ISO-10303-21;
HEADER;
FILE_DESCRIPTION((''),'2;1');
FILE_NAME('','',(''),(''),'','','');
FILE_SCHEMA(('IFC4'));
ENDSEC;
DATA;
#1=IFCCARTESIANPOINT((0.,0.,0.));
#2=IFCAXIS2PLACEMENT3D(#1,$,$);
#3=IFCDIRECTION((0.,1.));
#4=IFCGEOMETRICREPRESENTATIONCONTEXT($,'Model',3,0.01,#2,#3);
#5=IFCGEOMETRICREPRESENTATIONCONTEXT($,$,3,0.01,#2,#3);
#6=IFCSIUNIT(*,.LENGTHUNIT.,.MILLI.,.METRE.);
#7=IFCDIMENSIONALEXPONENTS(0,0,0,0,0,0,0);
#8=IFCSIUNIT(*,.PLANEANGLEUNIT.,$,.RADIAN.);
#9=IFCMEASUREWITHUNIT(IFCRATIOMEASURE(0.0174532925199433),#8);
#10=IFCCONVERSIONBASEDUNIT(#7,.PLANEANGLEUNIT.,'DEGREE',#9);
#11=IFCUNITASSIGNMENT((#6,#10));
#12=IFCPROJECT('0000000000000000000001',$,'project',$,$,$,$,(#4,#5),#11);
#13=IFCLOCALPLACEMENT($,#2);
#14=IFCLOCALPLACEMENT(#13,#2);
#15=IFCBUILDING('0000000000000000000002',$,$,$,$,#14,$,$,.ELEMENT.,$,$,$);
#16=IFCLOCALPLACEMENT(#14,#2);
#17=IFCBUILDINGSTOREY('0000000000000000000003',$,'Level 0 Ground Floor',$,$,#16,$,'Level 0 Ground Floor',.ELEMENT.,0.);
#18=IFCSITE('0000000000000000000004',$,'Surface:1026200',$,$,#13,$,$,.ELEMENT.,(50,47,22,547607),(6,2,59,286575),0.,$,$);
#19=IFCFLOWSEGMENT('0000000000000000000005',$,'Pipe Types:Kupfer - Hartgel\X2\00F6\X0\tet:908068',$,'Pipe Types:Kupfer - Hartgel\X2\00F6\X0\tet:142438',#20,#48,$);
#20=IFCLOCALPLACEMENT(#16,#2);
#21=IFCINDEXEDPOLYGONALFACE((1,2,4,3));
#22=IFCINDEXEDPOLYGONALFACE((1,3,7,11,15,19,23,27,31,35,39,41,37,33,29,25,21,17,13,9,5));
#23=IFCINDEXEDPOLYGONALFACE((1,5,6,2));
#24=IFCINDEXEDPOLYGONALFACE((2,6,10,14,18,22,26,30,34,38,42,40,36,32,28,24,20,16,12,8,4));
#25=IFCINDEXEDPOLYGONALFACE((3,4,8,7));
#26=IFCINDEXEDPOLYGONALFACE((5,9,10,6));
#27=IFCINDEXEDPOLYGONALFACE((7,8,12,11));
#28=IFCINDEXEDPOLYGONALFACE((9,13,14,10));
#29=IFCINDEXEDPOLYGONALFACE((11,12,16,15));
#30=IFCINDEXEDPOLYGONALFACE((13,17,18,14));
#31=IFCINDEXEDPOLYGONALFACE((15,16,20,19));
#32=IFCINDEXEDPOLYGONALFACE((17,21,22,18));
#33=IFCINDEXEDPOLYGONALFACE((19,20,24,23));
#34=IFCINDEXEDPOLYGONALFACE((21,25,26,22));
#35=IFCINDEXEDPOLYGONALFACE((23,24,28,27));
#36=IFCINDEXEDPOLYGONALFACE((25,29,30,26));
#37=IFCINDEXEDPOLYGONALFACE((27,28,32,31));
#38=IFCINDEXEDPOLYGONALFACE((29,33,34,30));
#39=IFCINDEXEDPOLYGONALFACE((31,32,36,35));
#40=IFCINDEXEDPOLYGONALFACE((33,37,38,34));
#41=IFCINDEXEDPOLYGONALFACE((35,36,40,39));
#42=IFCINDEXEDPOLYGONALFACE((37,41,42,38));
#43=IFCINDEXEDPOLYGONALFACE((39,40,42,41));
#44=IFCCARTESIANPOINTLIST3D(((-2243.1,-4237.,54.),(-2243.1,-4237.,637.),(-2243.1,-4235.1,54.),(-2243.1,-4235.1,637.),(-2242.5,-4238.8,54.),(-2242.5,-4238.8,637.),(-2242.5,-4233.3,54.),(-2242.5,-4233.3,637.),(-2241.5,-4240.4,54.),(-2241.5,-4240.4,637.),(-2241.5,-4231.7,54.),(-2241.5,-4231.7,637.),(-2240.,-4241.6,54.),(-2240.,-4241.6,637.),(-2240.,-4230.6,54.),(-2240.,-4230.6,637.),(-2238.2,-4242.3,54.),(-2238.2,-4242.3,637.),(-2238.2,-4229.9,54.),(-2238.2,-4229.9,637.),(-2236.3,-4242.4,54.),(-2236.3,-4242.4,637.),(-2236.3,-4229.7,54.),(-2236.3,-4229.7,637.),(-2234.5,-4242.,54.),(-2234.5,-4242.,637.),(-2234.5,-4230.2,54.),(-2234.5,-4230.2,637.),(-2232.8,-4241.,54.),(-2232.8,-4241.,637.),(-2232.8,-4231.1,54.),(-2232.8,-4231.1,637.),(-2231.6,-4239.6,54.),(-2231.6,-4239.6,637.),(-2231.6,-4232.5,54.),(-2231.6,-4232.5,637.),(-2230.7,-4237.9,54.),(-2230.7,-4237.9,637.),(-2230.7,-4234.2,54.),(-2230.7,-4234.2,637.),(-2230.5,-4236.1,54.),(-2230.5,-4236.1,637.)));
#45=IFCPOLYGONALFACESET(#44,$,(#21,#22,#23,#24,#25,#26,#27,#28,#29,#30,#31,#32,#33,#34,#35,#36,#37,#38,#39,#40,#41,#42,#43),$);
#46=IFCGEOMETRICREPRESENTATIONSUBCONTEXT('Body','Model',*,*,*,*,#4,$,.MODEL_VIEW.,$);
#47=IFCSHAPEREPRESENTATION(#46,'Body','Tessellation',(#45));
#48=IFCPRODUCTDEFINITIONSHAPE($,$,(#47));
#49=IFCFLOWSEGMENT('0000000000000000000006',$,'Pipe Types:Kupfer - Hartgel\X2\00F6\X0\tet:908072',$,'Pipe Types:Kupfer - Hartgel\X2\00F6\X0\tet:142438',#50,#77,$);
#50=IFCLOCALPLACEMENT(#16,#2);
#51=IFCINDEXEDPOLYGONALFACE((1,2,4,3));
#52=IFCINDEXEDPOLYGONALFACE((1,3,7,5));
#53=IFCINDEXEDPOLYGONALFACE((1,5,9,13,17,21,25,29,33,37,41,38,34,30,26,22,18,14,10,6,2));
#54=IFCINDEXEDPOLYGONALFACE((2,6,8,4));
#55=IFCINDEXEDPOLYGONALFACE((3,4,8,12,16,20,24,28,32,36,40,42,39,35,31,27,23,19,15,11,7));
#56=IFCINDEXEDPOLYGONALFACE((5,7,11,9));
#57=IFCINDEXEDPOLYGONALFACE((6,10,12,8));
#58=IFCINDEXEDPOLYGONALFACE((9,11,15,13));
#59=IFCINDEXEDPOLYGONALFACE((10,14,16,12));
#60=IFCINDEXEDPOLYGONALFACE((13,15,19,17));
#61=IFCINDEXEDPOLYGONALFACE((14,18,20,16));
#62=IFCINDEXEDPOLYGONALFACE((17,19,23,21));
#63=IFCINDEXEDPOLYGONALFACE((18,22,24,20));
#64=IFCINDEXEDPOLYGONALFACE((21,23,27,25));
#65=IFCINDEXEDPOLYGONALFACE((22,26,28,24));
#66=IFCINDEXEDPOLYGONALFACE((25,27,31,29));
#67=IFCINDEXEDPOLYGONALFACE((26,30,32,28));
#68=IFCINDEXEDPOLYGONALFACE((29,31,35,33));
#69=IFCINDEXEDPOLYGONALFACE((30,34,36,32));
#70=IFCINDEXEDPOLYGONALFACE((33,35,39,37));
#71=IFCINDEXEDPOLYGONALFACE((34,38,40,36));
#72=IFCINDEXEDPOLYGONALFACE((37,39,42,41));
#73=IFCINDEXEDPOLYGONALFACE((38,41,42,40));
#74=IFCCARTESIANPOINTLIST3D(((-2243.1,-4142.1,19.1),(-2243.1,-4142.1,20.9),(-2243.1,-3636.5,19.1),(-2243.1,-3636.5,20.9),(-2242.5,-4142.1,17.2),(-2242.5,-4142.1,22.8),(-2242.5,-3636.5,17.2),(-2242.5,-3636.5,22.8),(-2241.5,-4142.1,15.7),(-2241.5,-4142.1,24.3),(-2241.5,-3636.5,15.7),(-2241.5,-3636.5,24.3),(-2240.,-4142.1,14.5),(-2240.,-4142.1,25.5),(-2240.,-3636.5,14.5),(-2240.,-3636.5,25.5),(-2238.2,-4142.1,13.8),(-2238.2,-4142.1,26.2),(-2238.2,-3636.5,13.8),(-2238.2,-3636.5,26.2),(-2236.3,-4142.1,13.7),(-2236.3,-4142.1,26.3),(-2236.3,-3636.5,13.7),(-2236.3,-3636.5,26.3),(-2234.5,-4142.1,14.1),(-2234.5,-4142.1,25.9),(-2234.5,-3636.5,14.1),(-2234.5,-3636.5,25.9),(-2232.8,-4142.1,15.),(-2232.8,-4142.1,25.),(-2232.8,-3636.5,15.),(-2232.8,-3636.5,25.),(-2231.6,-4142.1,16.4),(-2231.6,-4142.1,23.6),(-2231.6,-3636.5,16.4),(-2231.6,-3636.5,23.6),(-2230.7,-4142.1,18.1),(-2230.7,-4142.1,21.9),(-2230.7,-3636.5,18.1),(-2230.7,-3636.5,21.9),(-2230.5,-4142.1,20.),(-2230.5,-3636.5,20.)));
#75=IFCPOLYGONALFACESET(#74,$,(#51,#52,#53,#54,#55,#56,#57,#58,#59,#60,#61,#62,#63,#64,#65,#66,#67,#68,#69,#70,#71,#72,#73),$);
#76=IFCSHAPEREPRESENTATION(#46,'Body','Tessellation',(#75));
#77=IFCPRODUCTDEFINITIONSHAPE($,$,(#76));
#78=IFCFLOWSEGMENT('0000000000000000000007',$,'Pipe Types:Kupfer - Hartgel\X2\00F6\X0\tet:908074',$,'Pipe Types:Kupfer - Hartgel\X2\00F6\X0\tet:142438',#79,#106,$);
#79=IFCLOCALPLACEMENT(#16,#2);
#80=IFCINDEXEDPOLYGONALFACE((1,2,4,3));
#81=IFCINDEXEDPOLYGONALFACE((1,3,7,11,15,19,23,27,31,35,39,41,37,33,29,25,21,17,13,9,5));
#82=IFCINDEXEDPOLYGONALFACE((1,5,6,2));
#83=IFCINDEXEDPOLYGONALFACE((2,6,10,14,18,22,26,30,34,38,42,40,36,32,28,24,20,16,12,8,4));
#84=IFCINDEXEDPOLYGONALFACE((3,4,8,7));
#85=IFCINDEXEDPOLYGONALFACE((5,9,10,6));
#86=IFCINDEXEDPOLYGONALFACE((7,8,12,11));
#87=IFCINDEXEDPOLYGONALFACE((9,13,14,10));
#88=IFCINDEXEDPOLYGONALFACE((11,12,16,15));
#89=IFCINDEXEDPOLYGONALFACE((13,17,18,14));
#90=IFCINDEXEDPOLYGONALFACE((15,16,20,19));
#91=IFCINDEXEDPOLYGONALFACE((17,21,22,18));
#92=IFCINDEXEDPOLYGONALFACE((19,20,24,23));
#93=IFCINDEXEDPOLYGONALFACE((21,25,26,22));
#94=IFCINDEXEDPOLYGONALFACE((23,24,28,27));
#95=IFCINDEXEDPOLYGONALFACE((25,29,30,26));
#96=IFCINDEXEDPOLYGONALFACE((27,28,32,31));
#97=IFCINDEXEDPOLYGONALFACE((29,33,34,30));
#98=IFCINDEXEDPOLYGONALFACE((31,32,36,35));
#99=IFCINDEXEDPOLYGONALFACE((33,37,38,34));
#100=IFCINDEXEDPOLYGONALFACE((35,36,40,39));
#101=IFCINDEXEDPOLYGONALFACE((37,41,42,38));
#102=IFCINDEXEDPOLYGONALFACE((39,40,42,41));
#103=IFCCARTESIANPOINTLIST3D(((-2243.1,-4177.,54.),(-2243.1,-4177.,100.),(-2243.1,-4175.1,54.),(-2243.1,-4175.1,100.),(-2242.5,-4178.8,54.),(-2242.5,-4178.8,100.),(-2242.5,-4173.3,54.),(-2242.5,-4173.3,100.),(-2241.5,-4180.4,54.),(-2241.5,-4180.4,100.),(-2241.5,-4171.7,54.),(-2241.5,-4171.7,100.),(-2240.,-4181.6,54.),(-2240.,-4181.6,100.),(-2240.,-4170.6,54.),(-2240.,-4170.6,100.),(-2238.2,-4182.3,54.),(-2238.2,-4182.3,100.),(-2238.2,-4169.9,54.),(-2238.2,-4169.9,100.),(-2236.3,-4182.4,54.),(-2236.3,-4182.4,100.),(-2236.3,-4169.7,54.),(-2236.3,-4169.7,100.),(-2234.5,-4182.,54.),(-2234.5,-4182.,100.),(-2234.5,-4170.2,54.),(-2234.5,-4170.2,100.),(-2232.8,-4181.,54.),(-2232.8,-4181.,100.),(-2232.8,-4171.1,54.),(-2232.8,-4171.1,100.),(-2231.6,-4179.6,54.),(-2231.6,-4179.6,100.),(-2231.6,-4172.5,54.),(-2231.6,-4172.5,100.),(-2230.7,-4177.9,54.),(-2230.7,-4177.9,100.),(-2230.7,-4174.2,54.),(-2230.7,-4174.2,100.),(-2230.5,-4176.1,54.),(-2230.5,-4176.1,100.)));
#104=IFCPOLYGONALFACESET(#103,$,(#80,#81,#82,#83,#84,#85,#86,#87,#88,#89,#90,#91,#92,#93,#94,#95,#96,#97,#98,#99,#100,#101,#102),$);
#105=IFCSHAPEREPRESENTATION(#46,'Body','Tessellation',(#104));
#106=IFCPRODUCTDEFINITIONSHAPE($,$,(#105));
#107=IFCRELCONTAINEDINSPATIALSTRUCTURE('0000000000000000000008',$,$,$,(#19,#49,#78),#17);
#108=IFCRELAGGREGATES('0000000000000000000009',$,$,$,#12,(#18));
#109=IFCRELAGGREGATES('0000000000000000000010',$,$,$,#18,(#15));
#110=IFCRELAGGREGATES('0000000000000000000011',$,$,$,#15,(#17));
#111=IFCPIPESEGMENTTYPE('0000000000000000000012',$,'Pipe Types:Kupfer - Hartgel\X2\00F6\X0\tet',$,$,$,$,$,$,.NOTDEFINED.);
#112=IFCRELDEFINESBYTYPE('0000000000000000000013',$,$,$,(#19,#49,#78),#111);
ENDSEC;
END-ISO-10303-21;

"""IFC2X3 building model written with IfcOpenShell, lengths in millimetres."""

from ifc_helpers import new_model, entity, si_unit, converted_unit, direction, frame, frame_2d, origin, origin_2d_with_axis, place, context, subcontext, project, spatial, circle, extrude, type_object, element, save


model = new_model("IFC2X3")

# Units and contexts
model_context = context("Model", 3, precision=0.01, world=origin(), true_north=direction((0.0, 1.0)))
context_of_model = context(None, 3, precision=0.01, world=origin(), true_north=direction((0.0, 1.0)))
body_context = subcontext(model_context, "Body", "Model", "MODEL_VIEW")
ifc_project = project(units=[si_unit("LENGTHUNIT", "METRE", prefix="MILLI"), converted_unit("PLANEANGLEUNIT", "DEGREE", entity("IfcRatioMeasure", 0.0174532925199433), si_unit("PLANEANGLEUNIT", "RADIAN"), dimensions=[0, 0, 0, 0, 0, 0, 0])], contexts=[model_context, context_of_model])

# Site, building, storey
site_placement = place(None, origin())
site = spatial("IfcSite", under=ifc_project, at=site_placement, Name="Surface:1026200", CompositionType="ELEMENT", RefLatitude=(50, 47, 22, 547607), RefLongitude=(6, 2, 59, 286575), RefElevation=0.0)
building_placement = place(site_placement, origin())
building = spatial("IfcBuilding", under=site, at=building_placement, CompositionType="ELEMENT")
storey_placement = place(building_placement, origin())
storey = spatial("IfcBuildingStorey", under=building, at=storey_placement, Name="Level 0 Ground Floor", LongName="Level 0 Ground Floor", CompositionType="ELEMENT", Elevation=0.0)

# Flow segments
pipe_segment_type = type_object("IfcPipeSegmentType", Name="Pipe Types:Kupfer - Hartgelötet", PredefinedType="NOTDEFINED")
flow_segment_1_placement = place(storey_placement, origin())
element("IfcFlowSegment", 1, at=flow_segment_1_placement, inside=storey, type_object=pipe_segment_type, Name="Pipe Types:Kupfer - Hartgelötet:908068", ObjectType="Pipe Types:Kupfer - Hartgelötet:142438", context=body_context, shape_type="SweptSolid", body=[
    extrude(circle(Radius=6.3, at=frame_2d((0.0, 0.0), x_axis=(1.0, 0.0))), frame((-2236.8, -4236.1, 54.0)), (0.0, 0.0, 1.0), 583.0),
])
flow_segment_2_placement = place(storey_placement, origin())
element("IfcFlowSegment", 2, at=flow_segment_2_placement, inside=storey, type_object=pipe_segment_type, Name="Pipe Types:Kupfer - Hartgelötet:908072", ObjectType="Pipe Types:Kupfer - Hartgelötet:142438", context=body_context, shape_type="SweptSolid", body=[
    extrude(circle(Radius=6.3, at=frame_2d((0.0, 0.0), x_axis=(1.0, 0.0))), frame((-2236.8, -4142.1, 20.0), z_axis=(0.0, 1.0, 0.0), x_axis=(1.0, 0.0, 0.0)), (0.0, 0.0, 1.0), 505.5),
])
flow_segment_3_placement = place(storey_placement, origin())
element("IfcFlowSegment", 3, at=flow_segment_3_placement, inside=storey, type_object=pipe_segment_type, Name="Pipe Types:Kupfer - Hartgelötet:908074", ObjectType="Pipe Types:Kupfer - Hartgelötet:142438", context=body_context, shape_type="SweptSolid", body=[
    extrude(circle(Radius=6.3, at=origin_2d_with_axis()), frame((-2236.8, -4176.1, 54.0)), (0.0, 0.0, 1.0), 46.0),
])

save(model, "model.ifc")
